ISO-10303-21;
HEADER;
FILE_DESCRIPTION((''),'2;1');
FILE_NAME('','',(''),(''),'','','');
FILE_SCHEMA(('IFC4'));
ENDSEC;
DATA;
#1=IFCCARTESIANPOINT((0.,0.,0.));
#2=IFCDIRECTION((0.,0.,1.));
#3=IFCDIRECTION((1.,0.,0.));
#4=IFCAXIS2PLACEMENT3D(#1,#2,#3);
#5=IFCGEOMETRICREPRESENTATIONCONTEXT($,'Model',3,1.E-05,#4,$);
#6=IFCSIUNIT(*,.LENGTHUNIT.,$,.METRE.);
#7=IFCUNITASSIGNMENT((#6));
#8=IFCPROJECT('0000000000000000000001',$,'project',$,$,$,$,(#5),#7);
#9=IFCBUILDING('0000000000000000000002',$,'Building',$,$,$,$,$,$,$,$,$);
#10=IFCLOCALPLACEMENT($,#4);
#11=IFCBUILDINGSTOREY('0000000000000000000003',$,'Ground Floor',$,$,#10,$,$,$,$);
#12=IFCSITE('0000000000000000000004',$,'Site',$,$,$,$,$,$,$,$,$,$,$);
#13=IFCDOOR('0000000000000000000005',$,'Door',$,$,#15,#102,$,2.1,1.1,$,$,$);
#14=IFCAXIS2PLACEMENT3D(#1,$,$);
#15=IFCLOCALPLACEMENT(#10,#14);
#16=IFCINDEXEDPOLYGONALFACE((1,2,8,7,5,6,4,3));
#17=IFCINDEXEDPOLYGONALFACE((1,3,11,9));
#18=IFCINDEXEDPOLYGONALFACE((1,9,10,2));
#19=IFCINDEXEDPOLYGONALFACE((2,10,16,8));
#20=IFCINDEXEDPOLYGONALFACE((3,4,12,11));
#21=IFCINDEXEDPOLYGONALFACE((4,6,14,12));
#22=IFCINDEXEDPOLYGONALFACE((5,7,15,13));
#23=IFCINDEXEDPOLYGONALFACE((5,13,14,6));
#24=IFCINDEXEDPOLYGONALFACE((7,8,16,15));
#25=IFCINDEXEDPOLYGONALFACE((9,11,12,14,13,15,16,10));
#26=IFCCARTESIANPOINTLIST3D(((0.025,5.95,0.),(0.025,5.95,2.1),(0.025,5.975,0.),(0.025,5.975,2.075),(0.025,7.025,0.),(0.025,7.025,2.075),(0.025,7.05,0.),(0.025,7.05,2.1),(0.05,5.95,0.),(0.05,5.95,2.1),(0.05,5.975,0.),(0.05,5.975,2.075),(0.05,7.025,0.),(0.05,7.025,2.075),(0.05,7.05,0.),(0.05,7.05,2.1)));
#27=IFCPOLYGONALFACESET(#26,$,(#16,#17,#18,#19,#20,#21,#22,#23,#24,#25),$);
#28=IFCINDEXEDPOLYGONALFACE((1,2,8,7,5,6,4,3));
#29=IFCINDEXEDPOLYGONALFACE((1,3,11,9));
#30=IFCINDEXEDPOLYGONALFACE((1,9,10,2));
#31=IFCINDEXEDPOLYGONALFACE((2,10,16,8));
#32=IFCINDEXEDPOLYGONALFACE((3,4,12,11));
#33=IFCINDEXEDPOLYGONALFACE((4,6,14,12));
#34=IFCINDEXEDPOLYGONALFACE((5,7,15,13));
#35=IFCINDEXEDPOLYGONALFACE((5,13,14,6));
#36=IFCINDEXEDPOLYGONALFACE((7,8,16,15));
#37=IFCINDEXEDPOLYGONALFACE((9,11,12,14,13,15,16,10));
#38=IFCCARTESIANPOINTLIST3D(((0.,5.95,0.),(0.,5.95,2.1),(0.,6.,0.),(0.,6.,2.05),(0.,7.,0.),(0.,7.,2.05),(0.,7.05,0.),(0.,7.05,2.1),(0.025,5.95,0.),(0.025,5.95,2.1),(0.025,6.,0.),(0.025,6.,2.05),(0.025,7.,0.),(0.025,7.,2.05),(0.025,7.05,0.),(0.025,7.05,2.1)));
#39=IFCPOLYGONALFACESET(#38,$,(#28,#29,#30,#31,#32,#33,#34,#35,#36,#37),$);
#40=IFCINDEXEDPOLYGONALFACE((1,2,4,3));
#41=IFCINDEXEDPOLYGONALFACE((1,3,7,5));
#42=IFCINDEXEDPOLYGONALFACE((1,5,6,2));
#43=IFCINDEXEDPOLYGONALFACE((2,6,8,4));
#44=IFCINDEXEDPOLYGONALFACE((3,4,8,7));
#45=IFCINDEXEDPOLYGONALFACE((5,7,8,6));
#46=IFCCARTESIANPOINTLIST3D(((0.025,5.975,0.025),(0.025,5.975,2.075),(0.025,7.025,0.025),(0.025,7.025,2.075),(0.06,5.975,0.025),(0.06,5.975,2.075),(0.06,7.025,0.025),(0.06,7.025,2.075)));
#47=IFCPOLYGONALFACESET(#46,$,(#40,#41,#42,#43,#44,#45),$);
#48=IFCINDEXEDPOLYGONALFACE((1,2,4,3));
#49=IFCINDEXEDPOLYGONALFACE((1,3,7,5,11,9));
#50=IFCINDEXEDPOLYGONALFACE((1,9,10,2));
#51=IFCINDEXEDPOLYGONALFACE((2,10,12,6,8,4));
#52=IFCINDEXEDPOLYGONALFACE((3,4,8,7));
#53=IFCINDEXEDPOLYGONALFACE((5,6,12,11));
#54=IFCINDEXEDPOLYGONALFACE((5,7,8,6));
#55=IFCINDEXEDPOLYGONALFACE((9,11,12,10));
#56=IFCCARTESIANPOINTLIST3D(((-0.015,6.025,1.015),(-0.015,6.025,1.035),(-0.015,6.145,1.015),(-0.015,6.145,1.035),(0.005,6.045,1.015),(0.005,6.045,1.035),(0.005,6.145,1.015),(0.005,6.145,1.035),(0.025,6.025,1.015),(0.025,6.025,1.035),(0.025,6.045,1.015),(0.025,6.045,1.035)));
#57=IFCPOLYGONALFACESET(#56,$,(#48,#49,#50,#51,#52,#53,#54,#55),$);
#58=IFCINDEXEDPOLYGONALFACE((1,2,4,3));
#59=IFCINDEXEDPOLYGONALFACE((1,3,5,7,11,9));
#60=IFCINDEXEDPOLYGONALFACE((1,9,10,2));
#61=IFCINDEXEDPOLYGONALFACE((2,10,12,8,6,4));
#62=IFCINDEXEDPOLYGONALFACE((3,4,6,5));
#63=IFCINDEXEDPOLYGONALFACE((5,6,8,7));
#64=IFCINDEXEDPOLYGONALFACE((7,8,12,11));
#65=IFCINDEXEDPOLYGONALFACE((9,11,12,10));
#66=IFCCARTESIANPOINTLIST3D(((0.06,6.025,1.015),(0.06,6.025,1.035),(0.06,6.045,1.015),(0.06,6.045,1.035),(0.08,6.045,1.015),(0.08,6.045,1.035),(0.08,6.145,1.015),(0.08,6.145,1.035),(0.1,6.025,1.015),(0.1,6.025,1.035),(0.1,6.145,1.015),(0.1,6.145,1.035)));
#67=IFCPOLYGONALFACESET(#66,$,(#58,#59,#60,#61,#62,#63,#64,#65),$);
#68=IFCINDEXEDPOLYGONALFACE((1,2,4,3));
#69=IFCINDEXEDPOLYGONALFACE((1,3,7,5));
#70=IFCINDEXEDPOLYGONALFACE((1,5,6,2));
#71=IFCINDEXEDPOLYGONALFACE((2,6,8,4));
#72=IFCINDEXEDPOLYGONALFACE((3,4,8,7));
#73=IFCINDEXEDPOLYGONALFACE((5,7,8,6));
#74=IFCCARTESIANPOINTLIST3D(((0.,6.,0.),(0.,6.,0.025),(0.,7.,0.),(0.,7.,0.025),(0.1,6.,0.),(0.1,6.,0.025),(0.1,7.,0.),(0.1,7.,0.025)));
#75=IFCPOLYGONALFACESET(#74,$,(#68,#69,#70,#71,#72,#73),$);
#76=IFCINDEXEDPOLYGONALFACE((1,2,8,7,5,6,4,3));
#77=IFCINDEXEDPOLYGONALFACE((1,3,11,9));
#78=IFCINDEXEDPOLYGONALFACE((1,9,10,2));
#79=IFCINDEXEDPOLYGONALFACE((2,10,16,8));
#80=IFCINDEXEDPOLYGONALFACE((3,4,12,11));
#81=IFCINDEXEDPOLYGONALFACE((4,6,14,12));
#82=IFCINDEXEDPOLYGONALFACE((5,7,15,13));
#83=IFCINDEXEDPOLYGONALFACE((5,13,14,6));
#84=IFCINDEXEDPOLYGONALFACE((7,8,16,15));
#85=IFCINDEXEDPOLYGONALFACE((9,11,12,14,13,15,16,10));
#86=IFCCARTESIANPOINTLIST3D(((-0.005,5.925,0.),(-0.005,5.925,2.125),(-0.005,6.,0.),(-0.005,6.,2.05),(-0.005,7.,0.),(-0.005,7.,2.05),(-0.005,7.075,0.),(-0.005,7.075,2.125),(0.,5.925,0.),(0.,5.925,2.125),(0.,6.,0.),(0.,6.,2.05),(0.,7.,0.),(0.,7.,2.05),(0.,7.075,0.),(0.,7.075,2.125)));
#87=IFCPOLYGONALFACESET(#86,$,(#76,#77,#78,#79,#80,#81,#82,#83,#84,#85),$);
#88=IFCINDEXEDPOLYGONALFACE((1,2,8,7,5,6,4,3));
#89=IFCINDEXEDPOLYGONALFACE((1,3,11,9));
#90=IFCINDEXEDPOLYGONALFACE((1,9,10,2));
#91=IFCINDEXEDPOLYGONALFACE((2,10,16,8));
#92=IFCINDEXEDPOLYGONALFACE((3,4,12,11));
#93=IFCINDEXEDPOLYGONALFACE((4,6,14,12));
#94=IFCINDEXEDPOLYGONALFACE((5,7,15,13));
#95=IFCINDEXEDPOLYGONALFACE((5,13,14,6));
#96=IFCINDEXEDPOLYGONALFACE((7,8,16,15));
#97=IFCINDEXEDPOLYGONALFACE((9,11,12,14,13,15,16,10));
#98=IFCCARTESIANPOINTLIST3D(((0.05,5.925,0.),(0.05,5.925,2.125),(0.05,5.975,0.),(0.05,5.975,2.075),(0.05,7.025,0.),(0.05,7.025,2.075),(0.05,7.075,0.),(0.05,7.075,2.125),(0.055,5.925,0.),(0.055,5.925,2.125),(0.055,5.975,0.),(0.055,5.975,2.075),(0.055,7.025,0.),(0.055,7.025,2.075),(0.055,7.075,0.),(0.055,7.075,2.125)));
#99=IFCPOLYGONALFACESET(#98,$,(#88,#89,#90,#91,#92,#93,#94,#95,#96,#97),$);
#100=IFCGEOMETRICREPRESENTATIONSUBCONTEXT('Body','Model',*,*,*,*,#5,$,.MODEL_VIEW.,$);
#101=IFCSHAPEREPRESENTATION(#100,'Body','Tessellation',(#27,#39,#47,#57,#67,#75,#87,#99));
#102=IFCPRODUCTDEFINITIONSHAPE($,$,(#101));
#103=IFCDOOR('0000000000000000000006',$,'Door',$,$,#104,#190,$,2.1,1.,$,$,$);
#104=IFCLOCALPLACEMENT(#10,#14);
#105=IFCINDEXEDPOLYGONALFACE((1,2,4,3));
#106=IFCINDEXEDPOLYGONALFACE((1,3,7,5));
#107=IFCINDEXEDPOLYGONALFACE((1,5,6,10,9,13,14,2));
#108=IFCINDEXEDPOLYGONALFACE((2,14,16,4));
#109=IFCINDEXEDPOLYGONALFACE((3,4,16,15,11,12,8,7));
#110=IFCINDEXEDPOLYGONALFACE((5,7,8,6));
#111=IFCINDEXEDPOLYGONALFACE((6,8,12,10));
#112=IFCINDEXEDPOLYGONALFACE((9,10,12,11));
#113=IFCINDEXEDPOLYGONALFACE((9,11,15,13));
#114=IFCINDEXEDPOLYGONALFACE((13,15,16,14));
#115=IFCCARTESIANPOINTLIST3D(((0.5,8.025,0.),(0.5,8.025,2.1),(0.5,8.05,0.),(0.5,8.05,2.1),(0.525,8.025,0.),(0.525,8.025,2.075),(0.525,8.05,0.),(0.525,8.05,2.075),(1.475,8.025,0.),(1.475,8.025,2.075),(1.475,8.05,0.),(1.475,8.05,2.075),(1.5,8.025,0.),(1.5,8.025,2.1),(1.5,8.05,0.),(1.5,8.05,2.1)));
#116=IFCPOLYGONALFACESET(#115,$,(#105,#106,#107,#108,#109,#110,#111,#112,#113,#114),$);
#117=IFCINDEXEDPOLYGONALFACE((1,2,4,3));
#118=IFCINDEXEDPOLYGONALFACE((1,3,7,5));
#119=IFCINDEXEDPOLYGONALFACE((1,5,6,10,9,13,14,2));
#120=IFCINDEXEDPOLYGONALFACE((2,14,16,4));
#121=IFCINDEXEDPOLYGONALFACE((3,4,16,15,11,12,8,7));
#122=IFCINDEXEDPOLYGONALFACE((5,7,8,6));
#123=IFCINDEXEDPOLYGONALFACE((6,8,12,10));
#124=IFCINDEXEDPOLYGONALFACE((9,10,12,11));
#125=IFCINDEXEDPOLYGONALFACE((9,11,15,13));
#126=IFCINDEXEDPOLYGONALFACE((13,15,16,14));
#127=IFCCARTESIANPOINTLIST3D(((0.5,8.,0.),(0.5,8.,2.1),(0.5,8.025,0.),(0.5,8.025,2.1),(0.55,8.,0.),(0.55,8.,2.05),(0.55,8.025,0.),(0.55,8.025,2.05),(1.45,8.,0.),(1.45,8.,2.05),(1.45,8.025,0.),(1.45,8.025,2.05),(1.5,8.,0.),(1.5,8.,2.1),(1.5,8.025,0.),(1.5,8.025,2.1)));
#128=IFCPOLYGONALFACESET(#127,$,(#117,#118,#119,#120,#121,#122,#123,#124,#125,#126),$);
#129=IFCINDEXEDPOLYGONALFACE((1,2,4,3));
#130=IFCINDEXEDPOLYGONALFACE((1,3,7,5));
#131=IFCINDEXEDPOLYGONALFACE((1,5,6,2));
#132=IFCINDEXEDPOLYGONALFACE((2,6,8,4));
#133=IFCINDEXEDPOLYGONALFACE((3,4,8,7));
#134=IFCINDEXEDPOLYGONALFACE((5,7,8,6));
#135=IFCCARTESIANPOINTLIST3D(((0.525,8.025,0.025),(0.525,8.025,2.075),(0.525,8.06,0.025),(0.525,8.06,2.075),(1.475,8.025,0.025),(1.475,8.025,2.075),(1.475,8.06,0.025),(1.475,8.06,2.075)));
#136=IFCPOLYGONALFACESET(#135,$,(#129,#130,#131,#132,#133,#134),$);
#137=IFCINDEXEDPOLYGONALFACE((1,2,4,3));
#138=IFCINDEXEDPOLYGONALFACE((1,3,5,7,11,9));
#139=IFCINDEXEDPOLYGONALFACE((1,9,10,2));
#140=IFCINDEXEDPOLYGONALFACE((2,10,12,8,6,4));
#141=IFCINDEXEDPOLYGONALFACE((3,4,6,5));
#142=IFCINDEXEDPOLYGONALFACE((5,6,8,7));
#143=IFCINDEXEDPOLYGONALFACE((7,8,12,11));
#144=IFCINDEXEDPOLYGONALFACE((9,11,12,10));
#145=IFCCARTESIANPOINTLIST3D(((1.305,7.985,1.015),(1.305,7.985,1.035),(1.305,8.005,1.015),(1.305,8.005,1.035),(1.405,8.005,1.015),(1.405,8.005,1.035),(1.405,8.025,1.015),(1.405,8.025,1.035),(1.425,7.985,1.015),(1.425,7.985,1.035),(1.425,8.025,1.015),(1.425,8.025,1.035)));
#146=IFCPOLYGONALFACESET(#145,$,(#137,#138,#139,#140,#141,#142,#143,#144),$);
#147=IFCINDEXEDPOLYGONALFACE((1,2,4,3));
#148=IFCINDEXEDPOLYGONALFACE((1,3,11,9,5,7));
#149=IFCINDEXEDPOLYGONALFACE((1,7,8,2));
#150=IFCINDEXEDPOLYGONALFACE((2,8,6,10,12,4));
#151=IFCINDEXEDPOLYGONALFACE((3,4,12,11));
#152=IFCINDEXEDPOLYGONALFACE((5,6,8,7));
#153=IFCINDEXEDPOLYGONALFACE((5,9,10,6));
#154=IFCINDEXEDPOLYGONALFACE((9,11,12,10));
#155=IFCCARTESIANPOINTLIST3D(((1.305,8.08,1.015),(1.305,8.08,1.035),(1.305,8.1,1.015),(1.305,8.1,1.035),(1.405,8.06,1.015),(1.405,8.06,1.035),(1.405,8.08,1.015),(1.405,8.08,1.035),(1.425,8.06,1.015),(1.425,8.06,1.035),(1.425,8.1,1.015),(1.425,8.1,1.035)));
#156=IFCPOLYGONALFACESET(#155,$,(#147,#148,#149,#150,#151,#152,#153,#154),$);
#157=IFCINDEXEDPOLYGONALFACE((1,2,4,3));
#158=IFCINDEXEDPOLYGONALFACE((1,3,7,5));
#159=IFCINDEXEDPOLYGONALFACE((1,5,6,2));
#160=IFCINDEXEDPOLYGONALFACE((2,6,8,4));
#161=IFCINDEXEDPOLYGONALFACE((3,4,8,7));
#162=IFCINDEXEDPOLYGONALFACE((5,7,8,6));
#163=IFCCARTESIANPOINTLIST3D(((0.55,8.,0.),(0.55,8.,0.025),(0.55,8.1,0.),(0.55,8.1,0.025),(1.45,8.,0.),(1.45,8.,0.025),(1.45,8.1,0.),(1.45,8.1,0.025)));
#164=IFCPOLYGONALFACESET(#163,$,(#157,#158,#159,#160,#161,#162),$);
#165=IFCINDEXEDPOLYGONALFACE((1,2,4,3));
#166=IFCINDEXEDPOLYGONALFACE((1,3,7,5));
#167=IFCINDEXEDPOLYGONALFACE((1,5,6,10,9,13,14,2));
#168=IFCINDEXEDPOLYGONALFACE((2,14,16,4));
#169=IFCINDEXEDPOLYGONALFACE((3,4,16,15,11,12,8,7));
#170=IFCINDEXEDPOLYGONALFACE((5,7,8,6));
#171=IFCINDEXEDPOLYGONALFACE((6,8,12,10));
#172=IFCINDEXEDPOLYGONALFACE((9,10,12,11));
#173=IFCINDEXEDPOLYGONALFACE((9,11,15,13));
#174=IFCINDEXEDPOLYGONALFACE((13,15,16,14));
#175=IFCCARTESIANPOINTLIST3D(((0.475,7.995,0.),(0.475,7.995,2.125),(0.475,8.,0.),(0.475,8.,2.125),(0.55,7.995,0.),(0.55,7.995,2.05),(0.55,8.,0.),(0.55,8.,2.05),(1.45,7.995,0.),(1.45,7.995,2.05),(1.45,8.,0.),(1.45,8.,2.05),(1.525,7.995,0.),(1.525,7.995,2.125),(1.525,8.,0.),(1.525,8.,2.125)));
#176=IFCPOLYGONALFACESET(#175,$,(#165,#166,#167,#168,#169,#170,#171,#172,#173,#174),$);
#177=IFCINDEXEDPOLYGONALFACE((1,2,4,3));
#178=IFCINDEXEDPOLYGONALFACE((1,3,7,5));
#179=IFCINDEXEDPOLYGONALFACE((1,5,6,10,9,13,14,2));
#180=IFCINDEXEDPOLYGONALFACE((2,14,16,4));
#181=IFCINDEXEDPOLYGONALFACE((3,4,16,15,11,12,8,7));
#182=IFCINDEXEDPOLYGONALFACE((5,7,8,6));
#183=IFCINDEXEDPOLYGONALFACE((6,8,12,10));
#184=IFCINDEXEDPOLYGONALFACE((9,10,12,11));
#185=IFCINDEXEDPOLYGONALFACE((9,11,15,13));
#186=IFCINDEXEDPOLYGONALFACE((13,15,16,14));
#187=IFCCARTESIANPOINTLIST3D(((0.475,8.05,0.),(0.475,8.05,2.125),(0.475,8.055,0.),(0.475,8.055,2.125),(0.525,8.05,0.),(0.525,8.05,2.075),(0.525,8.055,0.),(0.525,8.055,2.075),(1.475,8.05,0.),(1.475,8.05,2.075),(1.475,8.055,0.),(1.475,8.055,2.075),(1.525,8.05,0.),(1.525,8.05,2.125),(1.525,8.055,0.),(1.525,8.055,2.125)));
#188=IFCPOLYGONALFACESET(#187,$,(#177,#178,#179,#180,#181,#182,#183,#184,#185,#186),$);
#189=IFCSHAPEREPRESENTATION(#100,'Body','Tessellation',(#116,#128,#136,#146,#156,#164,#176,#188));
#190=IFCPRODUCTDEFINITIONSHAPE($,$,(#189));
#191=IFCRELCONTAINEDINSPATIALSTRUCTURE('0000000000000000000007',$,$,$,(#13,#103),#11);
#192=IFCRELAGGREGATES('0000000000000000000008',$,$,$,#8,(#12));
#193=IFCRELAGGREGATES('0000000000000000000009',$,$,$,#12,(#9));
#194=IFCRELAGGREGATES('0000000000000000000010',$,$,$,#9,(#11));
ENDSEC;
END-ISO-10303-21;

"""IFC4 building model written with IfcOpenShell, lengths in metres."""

from ifc_helpers import new_model, si_unit, frame, origin_with_axes, place, context, subcontext, project, spatial, line, indexed_curve, outline, extrude, element, save


model = new_model("IFC4")

# Units and contexts
model_context = context("Model", 3, precision=1e-05, world=origin_with_axes())
body_context = subcontext(model_context, "Body", "Model", "MODEL_VIEW")
ifc_project = project(units=[si_unit("LENGTHUNIT", "METRE")], contexts=[model_context])

# Site, building, storey
site = spatial("IfcSite", under=ifc_project, Name="Site")
building = spatial("IfcBuilding", under=site, Name="Building")
storey_placement = place(None, origin_with_axes())
storey = spatial("IfcBuildingStorey", under=building, at=storey_placement, Name="Ground Floor")

# Doors
door_1_placement = place(storey_placement, frame((0.0, 7.05, 0.0), z_axis=(0.0, 0.0, 1.0), x_axis=(0.0, -1.0, 0.0)))
element("IfcDoor", 1, at=door_1_placement, inside=storey, Name="Door", OverallHeight=2.1, OverallWidth=1.1, context=body_context, shape_type="SweptSolid", body=[
    extrude(outline(indexed_curve([(0.0, 0.0), (0.0, 2.1), (1.1, 2.1), (1.1, 0.0), (1.075, 0.0), (1.075, 2.075), (0.025, 2.075), (0.025, 0.0)], segments=[line(1, 2, 3, 4, 5, 6, 7, 8, 1)])), frame((0.0, 0.025, 0.0), z_axis=(0.0, -1.0, 0.0), x_axis=(1.0, 0.0, 0.0)), (0.0, 0.0, -1.0), 0.025),
    extrude(outline(indexed_curve([(0.0, 0.0), (0.0, 2.1), (1.1, 2.1), (1.1, 0.0), (1.05, 0.0), (1.05, 2.05), (0.05, 2.05), (0.05, 0.0)], segments=[line(1, 2, 3, 4, 5, 6, 7, 8, 1)])), frame((0.0, 0.0, 0.0), z_axis=(0.0, -1.0, 0.0), x_axis=(1.0, 0.0, 0.0)), (0.0, 0.0, -1.0), 0.025),
    extrude(outline(indexed_curve([(0.0, 0.0), (1.05, 0.0), (1.05, 0.035), (0.0, 0.035)], segments=[line(1, 2, 3, 4, 1)])), frame((0.025, 0.025, 0.025), z_axis=(0.0, 0.0, 1.0), x_axis=(1.0, 0.0, 0.0)), (0.0, 0.0, 1.0), 2.05),
    extrude(outline(indexed_curve([(0.0, 0.0), (0.0, -0.04), (-0.12, -0.04), (-0.12, -0.02), (-0.02, -0.02), (-0.02, 0.0)], segments=[line(1, 2, 3, 4, 5, 6, 1)])), frame((1.025, 0.025, 1.015), z_axis=(0.0, 0.0, 1.0), x_axis=(1.0, 0.0, 0.0)), (0.0, 0.0, 1.0), 0.02),
    extrude(outline(indexed_curve([(0.0, 0.0), (0.0, 0.04), (-0.12, 0.04), (-0.12, 0.02), (-0.02, 0.02), (-0.02, 0.0)], segments=[line(1, 2, 3, 4, 5, 6, 1)])), frame((1.025, 0.06, 1.015), z_axis=(0.0, 0.0, 1.0), x_axis=(1.0, 0.0, 0.0)), (0.0, 0.0, 1.0), 0.02),
    extrude(outline(indexed_curve([(0.0, 0.0), (1.0, 0.0), (1.0, 0.1), (0.0, 0.1)], segments=[line(1, 2, 3, 4, 1)])), frame((0.05, 0.0, 0.0), z_axis=(0.0, 0.0, 1.0), x_axis=(1.0, 0.0, 0.0)), (0.0, 0.0, 1.0), 0.025),
    extrude(outline(indexed_curve([(0.0, 0.0), (0.0, 2.125), (1.15, 2.125), (1.15, 0.0), (1.075, 0.0), (1.075, 2.05), (0.075, 2.05), (0.075, 0.0)], segments=[line(1, 2, 3, 4, 5, 6, 7, 8, 1)])), frame((-0.025, -0.005, 0.0), z_axis=(0.0, -1.0, 0.0), x_axis=(1.0, 0.0, 0.0)), (0.0, 0.0, -1.0), 0.005),
    extrude(outline(indexed_curve([(0.0, 0.0), (0.0, 2.125), (1.15, 2.125), (1.15, 0.0), (1.1, 0.0), (1.1, 2.075), (0.05, 2.075), (0.05, 0.0)], segments=[line(1, 2, 3, 4, 5, 6, 7, 8, 1)])), frame((-0.025, 0.05, 0.0), z_axis=(0.0, -1.0, 0.0), x_axis=(1.0, 0.0, 0.0)), (0.0, 0.0, -1.0), 0.005),
])
door_2_placement = place(storey_placement, frame((0.5, 8.0, 0.0), z_axis=(0.0, 0.0, 1.0), x_axis=(1.0, 0.0, 0.0)))
element("IfcDoor", 2, at=door_2_placement, inside=storey, Name="Door", OverallHeight=2.1, OverallWidth=1.0, context=body_context, shape_type="SweptSolid", body=[
    extrude(outline(indexed_curve([(0.0, 0.0), (0.0, 2.1), (1.0, 2.1), (1.0, 0.0), (0.975, 0.0), (0.975, 2.075), (0.025, 2.075), (0.025, 0.0)], segments=[line(1, 2, 3, 4, 5, 6, 7, 8, 1)])), frame((0.0, 0.025, 0.0), z_axis=(0.0, -1.0, 0.0), x_axis=(1.0, 0.0, 0.0)), (0.0, 0.0, -1.0), 0.025),
    extrude(outline(indexed_curve([(0.0, 0.0), (0.0, 2.1), (1.0, 2.1), (1.0, 0.0), (0.95, 0.0), (0.95, 2.05), (0.05, 2.05), (0.05, 0.0)], segments=[line(1, 2, 3, 4, 5, 6, 7, 8, 1)])), frame((0.0, 0.0, 0.0), z_axis=(0.0, -1.0, 0.0), x_axis=(1.0, 0.0, 0.0)), (0.0, 0.0, -1.0), 0.025),
    extrude(outline(indexed_curve([(0.0, 0.0), (0.95, 0.0), (0.95, 0.035), (0.0, 0.035)], segments=[line(1, 2, 3, 4, 1)])), frame((0.025, 0.025, 0.025), z_axis=(0.0, 0.0, 1.0), x_axis=(1.0, 0.0, 0.0)), (0.0, 0.0, 1.0), 2.05),
    extrude(outline(indexed_curve([(0.0, 0.0), (0.0, -0.04), (-0.12, -0.04), (-0.12, -0.02), (-0.02, -0.02), (-0.02, 0.0)], segments=[line(1, 2, 3, 4, 5, 6, 1)])), frame((0.925, 0.025, 1.015), z_axis=(0.0, 0.0, 1.0), x_axis=(1.0, 0.0, 0.0)), (0.0, 0.0, 1.0), 0.02),
    extrude(outline(indexed_curve([(0.0, 0.0), (0.0, 0.04), (-0.12, 0.04), (-0.12, 0.02), (-0.02, 0.02), (-0.02, 0.0)], segments=[line(1, 2, 3, 4, 5, 6, 1)])), frame((0.925, 0.06, 1.015), z_axis=(0.0, 0.0, 1.0), x_axis=(1.0, 0.0, 0.0)), (0.0, 0.0, 1.0), 0.02),
    extrude(outline(indexed_curve([(0.0, 0.0), (0.9, 0.0), (0.9, 0.1), (0.0, 0.1)], segments=[line(1, 2, 3, 4, 1)])), frame((0.05, 0.0, 0.0), z_axis=(0.0, 0.0, 1.0), x_axis=(1.0, 0.0, 0.0)), (0.0, 0.0, 1.0), 0.025),
    extrude(outline(indexed_curve([(0.0, 0.0), (0.0, 2.125), (1.05, 2.125), (1.05, 0.0), (0.975, 0.0), (0.975, 2.05), (0.075, 2.05), (0.075, 0.0)], segments=[line(1, 2, 3, 4, 5, 6, 7, 8, 1)])), frame((-0.025, -0.005, 0.0), z_axis=(0.0, -1.0, 0.0), x_axis=(1.0, 0.0, 0.0)), (0.0, 0.0, -1.0), 0.005),
    extrude(outline(indexed_curve([(0.0, 0.0), (0.0, 2.125), (1.05, 2.125), (1.05, 0.0), (1.0, 0.0), (1.0, 2.075), (0.05, 2.075), (0.05, 0.0)], segments=[line(1, 2, 3, 4, 5, 6, 7, 8, 1)])), frame((-0.025, 0.05, 0.0), z_axis=(0.0, -1.0, 0.0), x_axis=(1.0, 0.0, 0.0)), (0.0, 0.0, -1.0), 0.005),
])

save(model, "model.ifc")
